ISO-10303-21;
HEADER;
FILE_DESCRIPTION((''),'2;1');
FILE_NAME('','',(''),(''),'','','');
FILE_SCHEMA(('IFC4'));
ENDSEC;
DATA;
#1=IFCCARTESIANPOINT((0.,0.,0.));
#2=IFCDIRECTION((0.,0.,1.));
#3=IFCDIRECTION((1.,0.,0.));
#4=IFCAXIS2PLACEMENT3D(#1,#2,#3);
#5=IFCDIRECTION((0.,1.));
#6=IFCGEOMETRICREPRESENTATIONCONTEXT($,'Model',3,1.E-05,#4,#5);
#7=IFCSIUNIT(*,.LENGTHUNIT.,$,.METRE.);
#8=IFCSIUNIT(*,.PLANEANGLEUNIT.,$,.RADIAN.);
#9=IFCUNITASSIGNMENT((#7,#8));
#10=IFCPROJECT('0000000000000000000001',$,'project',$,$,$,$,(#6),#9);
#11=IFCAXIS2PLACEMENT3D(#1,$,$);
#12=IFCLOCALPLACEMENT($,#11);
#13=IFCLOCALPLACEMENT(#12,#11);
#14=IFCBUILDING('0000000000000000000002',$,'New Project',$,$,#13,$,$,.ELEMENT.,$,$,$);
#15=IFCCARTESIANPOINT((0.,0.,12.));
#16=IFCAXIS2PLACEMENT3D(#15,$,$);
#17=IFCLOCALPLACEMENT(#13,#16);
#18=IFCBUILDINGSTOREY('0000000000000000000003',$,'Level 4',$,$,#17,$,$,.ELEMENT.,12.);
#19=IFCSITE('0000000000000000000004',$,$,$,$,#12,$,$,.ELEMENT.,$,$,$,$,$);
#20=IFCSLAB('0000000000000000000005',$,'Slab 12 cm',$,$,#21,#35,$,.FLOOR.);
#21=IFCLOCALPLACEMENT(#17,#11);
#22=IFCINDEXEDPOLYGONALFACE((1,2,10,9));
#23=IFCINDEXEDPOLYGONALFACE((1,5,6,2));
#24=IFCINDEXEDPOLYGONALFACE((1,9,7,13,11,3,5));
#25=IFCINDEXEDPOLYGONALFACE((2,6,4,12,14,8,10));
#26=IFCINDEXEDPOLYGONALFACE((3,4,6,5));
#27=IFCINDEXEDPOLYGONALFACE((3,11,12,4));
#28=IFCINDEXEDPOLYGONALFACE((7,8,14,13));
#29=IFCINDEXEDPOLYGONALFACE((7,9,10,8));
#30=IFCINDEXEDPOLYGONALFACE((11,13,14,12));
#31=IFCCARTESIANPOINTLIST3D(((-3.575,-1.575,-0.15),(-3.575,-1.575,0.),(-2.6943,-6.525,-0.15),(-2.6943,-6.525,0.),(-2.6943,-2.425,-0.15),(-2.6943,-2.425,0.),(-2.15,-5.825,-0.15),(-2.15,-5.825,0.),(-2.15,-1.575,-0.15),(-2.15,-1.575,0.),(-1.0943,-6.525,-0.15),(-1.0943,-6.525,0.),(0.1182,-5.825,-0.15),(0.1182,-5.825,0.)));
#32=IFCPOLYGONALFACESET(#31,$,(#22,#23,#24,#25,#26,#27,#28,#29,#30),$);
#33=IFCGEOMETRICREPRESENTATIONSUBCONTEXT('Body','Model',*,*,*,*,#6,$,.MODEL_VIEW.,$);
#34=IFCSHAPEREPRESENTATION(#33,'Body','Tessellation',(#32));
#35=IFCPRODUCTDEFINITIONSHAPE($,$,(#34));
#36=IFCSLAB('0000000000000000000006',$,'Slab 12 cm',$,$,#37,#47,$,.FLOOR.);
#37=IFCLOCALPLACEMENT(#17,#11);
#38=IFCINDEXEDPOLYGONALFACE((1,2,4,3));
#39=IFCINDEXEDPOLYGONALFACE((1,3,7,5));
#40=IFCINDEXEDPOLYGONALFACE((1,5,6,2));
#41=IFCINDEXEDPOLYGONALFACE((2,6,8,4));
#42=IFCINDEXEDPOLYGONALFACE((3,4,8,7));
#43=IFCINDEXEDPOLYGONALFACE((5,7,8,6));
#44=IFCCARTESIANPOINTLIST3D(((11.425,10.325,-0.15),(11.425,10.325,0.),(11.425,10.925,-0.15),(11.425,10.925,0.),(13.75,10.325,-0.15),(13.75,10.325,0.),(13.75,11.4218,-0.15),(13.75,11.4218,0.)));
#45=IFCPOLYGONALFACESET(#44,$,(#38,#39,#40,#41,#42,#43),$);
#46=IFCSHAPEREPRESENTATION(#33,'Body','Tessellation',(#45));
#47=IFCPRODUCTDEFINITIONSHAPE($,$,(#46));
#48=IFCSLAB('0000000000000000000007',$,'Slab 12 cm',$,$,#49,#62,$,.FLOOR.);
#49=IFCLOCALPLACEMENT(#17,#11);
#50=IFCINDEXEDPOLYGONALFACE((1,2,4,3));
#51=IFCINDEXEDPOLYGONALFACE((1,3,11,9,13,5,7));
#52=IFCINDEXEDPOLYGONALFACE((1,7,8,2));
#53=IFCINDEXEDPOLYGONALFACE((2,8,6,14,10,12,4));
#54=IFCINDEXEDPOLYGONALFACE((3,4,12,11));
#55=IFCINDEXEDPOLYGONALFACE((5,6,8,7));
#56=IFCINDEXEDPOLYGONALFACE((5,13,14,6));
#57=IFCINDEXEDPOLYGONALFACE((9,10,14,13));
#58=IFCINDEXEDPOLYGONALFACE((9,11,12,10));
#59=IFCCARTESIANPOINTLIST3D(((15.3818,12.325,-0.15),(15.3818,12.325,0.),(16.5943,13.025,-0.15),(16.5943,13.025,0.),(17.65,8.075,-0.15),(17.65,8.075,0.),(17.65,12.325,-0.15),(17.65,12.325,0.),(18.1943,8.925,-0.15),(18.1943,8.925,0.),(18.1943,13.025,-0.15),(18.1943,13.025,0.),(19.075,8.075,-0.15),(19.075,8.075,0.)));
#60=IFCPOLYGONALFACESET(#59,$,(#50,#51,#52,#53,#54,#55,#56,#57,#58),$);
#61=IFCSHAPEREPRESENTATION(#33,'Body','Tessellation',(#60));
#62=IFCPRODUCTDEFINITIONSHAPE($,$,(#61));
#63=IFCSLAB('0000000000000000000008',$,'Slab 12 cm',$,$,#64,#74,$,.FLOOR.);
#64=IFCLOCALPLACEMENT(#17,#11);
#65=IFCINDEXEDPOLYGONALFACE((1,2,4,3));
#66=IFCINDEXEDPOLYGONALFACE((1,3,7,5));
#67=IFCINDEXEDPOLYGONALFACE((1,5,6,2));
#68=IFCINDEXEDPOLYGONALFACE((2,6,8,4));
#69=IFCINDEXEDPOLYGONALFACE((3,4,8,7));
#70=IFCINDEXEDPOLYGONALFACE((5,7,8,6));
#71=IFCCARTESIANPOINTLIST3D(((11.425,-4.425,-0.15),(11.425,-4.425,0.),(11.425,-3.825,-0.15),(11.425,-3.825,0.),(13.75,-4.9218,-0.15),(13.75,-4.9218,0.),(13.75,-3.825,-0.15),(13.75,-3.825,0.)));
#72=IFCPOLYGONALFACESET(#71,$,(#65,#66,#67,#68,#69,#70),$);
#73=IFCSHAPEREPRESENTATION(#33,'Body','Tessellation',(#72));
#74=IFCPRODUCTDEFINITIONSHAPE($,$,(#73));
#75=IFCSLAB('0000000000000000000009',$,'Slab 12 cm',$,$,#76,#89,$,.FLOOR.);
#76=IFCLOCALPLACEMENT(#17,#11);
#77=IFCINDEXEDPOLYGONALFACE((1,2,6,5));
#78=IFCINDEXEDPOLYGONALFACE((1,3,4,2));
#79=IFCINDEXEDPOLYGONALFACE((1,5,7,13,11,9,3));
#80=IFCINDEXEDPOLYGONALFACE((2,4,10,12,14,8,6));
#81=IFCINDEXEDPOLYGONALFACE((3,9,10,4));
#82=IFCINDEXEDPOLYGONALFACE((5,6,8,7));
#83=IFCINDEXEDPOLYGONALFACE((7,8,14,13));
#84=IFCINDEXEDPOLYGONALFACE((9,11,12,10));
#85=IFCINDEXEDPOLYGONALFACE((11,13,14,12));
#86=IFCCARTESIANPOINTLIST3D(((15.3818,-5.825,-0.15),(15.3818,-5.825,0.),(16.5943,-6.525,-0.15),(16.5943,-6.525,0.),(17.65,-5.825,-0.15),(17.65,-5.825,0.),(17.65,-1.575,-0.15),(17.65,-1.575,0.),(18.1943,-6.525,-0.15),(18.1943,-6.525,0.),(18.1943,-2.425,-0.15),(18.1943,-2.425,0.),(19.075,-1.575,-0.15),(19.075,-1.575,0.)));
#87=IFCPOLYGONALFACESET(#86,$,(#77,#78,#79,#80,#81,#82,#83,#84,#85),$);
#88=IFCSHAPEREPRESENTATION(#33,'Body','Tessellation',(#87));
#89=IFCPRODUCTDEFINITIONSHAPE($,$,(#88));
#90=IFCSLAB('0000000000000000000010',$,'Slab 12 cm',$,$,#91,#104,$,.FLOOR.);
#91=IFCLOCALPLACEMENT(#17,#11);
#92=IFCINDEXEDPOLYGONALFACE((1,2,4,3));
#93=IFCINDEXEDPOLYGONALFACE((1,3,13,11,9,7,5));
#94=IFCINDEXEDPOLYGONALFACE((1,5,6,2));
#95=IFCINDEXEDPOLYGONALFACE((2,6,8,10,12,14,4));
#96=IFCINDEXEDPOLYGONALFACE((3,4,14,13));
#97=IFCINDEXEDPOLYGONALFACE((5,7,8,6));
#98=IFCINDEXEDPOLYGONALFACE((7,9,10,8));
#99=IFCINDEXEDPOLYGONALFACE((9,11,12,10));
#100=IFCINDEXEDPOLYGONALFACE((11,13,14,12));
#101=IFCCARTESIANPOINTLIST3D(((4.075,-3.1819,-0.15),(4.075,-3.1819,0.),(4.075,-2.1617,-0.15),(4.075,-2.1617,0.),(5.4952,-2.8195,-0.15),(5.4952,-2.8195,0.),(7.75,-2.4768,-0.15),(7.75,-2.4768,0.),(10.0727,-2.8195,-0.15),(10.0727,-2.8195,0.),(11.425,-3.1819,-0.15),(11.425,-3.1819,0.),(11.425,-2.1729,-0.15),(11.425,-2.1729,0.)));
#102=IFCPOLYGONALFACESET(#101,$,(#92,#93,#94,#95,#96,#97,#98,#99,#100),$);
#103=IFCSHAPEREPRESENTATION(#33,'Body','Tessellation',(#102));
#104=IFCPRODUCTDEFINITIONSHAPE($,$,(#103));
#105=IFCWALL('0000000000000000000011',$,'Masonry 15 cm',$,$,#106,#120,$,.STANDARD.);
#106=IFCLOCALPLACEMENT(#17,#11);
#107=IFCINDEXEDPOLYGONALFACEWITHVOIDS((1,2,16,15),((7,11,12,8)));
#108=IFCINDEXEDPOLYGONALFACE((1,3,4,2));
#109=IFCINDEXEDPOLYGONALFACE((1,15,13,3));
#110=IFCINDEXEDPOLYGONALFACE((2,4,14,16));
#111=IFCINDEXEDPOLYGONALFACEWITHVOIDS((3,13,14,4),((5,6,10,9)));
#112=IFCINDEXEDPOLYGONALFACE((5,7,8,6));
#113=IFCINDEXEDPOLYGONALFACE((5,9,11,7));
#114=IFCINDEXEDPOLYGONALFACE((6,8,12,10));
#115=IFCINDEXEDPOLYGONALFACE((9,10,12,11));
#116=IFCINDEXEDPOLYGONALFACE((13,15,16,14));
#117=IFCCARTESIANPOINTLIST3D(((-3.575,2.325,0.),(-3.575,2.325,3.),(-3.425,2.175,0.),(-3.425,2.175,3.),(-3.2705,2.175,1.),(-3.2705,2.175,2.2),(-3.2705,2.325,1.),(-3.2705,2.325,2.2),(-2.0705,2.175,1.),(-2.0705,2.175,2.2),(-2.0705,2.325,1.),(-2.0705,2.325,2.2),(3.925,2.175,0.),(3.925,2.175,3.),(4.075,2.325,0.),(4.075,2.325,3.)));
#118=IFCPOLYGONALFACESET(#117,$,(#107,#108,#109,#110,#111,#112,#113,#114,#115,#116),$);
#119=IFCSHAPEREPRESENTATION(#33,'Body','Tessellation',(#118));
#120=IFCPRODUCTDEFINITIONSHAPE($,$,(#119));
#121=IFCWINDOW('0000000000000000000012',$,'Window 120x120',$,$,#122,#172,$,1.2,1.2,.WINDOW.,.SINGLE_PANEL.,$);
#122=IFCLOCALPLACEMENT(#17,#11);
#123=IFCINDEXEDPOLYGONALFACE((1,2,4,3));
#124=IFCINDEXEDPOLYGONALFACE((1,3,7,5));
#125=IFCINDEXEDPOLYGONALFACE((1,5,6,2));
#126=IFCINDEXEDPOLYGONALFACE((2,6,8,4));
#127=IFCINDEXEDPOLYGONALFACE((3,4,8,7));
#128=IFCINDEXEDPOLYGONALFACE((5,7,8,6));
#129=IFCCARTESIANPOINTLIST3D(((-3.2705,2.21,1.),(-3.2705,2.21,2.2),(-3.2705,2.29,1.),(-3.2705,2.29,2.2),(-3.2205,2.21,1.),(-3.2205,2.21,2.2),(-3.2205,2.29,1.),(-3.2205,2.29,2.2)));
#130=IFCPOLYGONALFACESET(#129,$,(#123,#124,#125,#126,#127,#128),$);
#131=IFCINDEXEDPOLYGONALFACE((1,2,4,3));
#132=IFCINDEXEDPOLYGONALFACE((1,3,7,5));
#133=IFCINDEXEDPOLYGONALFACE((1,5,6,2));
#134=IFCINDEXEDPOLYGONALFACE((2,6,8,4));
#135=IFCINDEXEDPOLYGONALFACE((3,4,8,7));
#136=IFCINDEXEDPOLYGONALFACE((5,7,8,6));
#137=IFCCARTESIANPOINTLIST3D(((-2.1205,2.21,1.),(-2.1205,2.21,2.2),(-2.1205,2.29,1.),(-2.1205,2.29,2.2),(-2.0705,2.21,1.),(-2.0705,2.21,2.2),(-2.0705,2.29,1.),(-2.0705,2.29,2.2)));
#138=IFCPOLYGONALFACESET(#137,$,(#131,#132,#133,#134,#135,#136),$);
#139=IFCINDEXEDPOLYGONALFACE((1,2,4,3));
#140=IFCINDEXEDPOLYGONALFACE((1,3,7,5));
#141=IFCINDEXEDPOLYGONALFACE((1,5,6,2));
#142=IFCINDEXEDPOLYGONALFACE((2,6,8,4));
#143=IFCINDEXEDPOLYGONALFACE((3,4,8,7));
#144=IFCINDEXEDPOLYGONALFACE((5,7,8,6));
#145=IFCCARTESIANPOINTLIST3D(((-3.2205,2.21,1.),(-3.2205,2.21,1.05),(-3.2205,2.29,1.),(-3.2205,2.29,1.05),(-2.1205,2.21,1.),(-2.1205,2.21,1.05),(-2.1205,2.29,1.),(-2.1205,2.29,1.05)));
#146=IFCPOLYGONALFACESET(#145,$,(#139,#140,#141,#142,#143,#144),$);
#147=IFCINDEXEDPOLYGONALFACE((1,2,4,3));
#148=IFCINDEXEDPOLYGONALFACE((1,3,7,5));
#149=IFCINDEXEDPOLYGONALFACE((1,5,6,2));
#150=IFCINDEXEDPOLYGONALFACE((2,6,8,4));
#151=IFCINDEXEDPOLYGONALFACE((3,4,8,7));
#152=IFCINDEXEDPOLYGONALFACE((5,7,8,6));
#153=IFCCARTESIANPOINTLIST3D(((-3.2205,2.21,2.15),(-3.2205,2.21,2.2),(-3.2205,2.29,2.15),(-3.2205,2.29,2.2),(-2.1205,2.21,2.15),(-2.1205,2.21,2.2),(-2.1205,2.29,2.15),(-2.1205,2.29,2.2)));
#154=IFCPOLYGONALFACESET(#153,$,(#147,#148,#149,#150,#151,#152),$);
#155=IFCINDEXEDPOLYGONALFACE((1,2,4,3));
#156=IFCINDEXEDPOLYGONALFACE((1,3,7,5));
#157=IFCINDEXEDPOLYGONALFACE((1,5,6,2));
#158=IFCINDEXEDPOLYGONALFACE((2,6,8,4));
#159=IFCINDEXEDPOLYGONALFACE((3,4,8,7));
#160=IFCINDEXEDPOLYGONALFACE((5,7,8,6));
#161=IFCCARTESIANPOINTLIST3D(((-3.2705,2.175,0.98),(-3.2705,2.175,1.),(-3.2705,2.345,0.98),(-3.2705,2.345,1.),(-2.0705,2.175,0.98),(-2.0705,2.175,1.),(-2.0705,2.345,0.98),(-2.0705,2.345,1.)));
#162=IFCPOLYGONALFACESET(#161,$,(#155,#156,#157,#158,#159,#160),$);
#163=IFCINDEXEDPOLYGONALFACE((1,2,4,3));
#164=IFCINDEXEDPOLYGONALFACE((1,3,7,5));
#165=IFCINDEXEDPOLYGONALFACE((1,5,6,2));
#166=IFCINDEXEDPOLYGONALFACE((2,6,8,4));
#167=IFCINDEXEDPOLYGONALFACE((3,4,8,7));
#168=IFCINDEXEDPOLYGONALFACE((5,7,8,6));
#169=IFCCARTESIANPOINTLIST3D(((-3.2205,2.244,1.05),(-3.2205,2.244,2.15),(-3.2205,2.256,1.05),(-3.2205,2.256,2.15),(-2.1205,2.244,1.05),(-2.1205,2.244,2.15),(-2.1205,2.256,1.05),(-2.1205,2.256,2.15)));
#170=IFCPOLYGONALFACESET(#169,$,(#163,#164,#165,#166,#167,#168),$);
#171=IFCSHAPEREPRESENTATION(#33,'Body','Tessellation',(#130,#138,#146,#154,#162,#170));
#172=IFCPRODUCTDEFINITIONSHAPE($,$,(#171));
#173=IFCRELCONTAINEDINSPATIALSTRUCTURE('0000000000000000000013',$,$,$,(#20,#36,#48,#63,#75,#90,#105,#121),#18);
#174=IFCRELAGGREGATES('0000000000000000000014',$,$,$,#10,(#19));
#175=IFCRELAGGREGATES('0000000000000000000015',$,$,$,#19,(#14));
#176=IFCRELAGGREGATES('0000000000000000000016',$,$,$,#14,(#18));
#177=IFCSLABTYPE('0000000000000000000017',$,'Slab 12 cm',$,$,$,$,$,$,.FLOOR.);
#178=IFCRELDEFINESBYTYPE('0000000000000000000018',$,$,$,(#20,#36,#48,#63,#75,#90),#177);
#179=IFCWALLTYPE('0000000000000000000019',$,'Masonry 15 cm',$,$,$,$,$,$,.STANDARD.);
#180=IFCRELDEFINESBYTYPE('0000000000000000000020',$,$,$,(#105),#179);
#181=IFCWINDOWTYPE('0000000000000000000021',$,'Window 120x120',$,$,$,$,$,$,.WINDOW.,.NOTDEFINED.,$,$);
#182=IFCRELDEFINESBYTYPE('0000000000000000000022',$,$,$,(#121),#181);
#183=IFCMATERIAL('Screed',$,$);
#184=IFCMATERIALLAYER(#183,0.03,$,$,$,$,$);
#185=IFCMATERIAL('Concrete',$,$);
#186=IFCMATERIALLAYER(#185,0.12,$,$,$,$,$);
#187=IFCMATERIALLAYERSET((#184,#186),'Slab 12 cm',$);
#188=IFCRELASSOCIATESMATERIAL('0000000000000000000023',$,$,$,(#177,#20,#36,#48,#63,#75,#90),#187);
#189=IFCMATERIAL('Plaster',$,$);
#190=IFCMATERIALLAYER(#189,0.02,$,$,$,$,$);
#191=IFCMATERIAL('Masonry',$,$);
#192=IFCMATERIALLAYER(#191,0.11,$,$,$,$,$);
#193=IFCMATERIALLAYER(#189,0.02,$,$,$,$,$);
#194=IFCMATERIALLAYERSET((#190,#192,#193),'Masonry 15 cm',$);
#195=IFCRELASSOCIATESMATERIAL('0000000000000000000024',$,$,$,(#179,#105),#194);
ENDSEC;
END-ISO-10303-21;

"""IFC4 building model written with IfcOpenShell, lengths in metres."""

from ifc_helpers import new_model, si_unit, direction, frame, frame_2d, origin, origin_with_axes, place, context, subcontext, project, spatial, polyline, rectangle, outline, extrude, material, layer, layer_set, layer_usage, type_object, element, fill, save


model = new_model("IFC4")

# Units and contexts
model_context = context("Model", 3, precision=1e-05, world=origin_with_axes(), true_north=direction((0.0, 1.0)))
body_context = subcontext(model_context, "Body", "Model", "MODEL_VIEW")
ifc_project = project(units=[si_unit("LENGTHUNIT", "METRE"), si_unit("PLANEANGLEUNIT", "RADIAN")], contexts=[model_context])

# Site, building, storey
site_placement = place(None, origin())
site = spatial("IfcSite", under=ifc_project, at=site_placement, CompositionType="ELEMENT")
building_placement = place(site_placement, origin())
building = spatial("IfcBuilding", under=site, at=building_placement, Name="New Project", CompositionType="ELEMENT")
storey_placement = place(building_placement, frame((0.0, 0.0, 12.0)))
storey = spatial("IfcBuildingStorey", under=building, at=storey_placement, Name="Level 4", CompositionType="ELEMENT", Elevation=12.0)

# Slabs
ifc_material_1 = material(Name="Screed")
ifc_layer_1 = layer(ifc_material_1, 0.03)
ifc_material_2 = material(Name="Concrete")
ifc_layer_2 = layer(ifc_material_2, 0.12)
ifc_layer_set_1 = layer_set([ifc_layer_1, ifc_layer_2], Name="Slab 12 cm")
ifc_layer_usage_1 = layer_usage(ifc_layer_set_1, "AXIS3", "NEGATIVE", 0.15)
slab_type = type_object("IfcSlabType", Name="Slab 12 cm", PredefinedType="FLOOR", material=ifc_layer_set_1)
slab_1_placement = place(storey_placement, frame((0.0, 0.0, -0.15)))
element("IfcSlab", 1, at=slab_1_placement, inside=storey, type_object=slab_type, material=ifc_layer_usage_1, Name="Slab 12 cm", PredefinedType="FLOOR", context=body_context, shape_type="SweptSolid", body=[
    extrude(outline(polyline([(-2.15, -5.825), (-2.15, -1.575), (-3.575, -1.575), (-2.6943, -2.425), (-2.6943, -6.525), (-1.0943, -6.525), (0.1182, -5.825), (-2.15, -5.825)])), origin(), (0.0, 0.0, 1.0), 0.15),
])
slab_2_placement = place(storey_placement, frame((0.0, 0.0, -0.15)))
element("IfcSlab", 2, at=slab_2_placement, inside=storey, type_object=slab_type, material=ifc_layer_usage_1, Name="Slab 12 cm", PredefinedType="FLOOR", context=body_context, shape_type="SweptSolid", body=[
    extrude(outline(polyline([(13.75, 10.325), (13.75, 11.4218), (11.425, 10.925), (11.425, 10.325), (13.75, 10.325)])), origin(), (0.0, 0.0, 1.0), 0.15),
])
slab_3_placement = place(storey_placement, frame((0.0, 0.0, -0.15)))
element("IfcSlab", 3, at=slab_3_placement, inside=storey, type_object=slab_type, material=ifc_layer_usage_1, Name="Slab 12 cm", PredefinedType="FLOOR", context=body_context, shape_type="SweptSolid", body=[
    extrude(outline(polyline([(17.65, 12.325), (17.65, 8.075), (19.075, 8.075), (18.1943, 8.925), (18.1943, 13.025), (16.5943, 13.025), (15.3818, 12.325), (17.65, 12.325)])), origin(), (0.0, 0.0, 1.0), 0.15),
])
slab_4_placement = place(storey_placement, frame((0.0, 0.0, -0.15)))
element("IfcSlab", 4, at=slab_4_placement, inside=storey, type_object=slab_type, material=ifc_layer_usage_1, Name="Slab 12 cm", PredefinedType="FLOOR", context=body_context, shape_type="SweptSolid", body=[
    extrude(outline(polyline([(11.425, -3.825), (11.425, -4.425), (13.75, -4.9218), (13.75, -3.825), (11.425, -3.825)])), origin(), (0.0, 0.0, 1.0), 0.15),
])
slab_5_placement = place(storey_placement, frame((0.0, 0.0, -0.15)))
element("IfcSlab", 5, at=slab_5_placement, inside=storey, type_object=slab_type, material=ifc_layer_usage_1, Name="Slab 12 cm", PredefinedType="FLOOR", context=body_context, shape_type="SweptSolid", body=[
    extrude(outline(polyline([(15.3818, -5.825), (16.5943, -6.525), (18.1943, -6.525), (18.1943, -2.425), (19.075, -1.575), (17.65, -1.575), (17.65, -5.825), (15.3818, -5.825)])), origin(), (0.0, 0.0, 1.0), 0.15),
])
slab_6_placement = place(storey_placement, frame((0.0, 0.0, -0.15)))
element("IfcSlab", 6, at=slab_6_placement, inside=storey, type_object=slab_type, material=ifc_layer_usage_1, Name="Slab 12 cm", PredefinedType="FLOOR", context=body_context, shape_type="SweptSolid", body=[
    extrude(outline(polyline([(4.075, -3.1819), (5.4952, -2.8195), (7.75, -2.4768), (10.0727, -2.8195), (11.425, -3.1819), (11.425, -2.1729), (4.075, -2.1617), (4.075, -3.1819)])), origin(), (0.0, 0.0, 1.0), 0.15),
])

# Wall, opening, window
ifc_material_3 = material(Name="Plaster")
ifc_layer_3 = layer(ifc_material_3, 0.02)
ifc_material_4 = material(Name="Masonry")
ifc_layer_4 = layer(ifc_material_4, 0.11)
ifc_layer_5 = layer(ifc_material_3, 0.02)
ifc_layer_set_2 = layer_set([ifc_layer_3, ifc_layer_4, ifc_layer_5], Name="Masonry 15 cm")
ifc_layer_usage_2 = layer_usage(ifc_layer_set_2, "AXIS2", "NEGATIVE", 0.075)
wall_type = type_object("IfcWallType", Name="Masonry 15 cm", PredefinedType="STANDARD", material=ifc_layer_set_2)
wall_1_placement = place(storey_placement, frame((-3.5, 2.25, 0.0)))
wall_1 = element("IfcWall", 7, at=wall_1_placement, inside=storey, type_object=wall_type, material=ifc_layer_usage_2, Name="Masonry 15 cm", PredefinedType="STANDARD", context=body_context, shape_type="SweptSolid", body=[
    extrude(outline(polyline([(0.075, -0.075), (7.425, -0.075), (7.575, 0.075), (-0.075, 0.075), (0.075, -0.075)])), origin(), (0.0, 0.0, 1.0), 3.0),
])
opening_1_placement = place(wall_1_placement, frame((0.2295, 0.0, 1.0)))
opening_1 = element("IfcOpeningElement", 8, at=opening_1_placement, cuts=wall_1, PredefinedType="OPENING", context=body_context, shape_type="SweptSolid", body=[
    extrude(rectangle(XDim=1.2, YDim=0.25, at=frame_2d((0.6, 0.0))), origin(), (0.0, 0.0, 1.0), 1.2),
])
window_type = type_object("IfcWindowType", Name="Window 120x120", PartitioningType="NOTDEFINED", PredefinedType="WINDOW")
window_1_placement = place(opening_1_placement, origin())
window_1 = element("IfcWindow", 9, at=window_1_placement, inside=storey, type_object=window_type, Name="Window 120x120", OverallHeight=1.2, OverallWidth=1.2, PartitioningType="SINGLE_PANEL", PredefinedType="WINDOW", context=body_context, shape_type="SweptSolid", body=[
    extrude(outline(polyline([(0.0, -0.04), (0.05, -0.04), (0.05, 0.04), (0.0, 0.04), (0.0, -0.04)])), origin(), (0.0, 0.0, 1.0), 1.2),
    extrude(outline(polyline([(1.15, -0.04), (1.2, -0.04), (1.2, 0.04), (1.15, 0.04), (1.15, -0.04)])), origin(), (0.0, 0.0, 1.0), 1.2),
    extrude(outline(polyline([(0.05, -0.04), (1.15, -0.04), (1.15, 0.04), (0.05, 0.04), (0.05, -0.04)])), origin(), (0.0, 0.0, 1.0), 0.05),
    extrude(outline(polyline([(0.05, -0.04), (1.15, -0.04), (1.15, 0.04), (0.05, 0.04), (0.05, -0.04)])), frame((0.0, 0.0, 1.15)), (0.0, 0.0, 1.0), 0.05),
    extrude(outline(polyline([(0.0, -0.075), (1.2, -0.075), (1.2, 0.095), (0.0, 0.095), (0.0, -0.075)])), frame((0.0, 0.0, -0.02)), (0.0, 0.0, 1.0), 0.02),
    extrude(outline(polyline([(0.05, -0.006), (1.15, -0.006), (1.15, 0.006), (0.05, 0.006), (0.05, -0.006)])), frame((0.0, 0.0, 0.05)), (0.0, 0.0, 1.0), 1.1),
])
fill(opening_1, window_1)

save(model, "model.ifc")
